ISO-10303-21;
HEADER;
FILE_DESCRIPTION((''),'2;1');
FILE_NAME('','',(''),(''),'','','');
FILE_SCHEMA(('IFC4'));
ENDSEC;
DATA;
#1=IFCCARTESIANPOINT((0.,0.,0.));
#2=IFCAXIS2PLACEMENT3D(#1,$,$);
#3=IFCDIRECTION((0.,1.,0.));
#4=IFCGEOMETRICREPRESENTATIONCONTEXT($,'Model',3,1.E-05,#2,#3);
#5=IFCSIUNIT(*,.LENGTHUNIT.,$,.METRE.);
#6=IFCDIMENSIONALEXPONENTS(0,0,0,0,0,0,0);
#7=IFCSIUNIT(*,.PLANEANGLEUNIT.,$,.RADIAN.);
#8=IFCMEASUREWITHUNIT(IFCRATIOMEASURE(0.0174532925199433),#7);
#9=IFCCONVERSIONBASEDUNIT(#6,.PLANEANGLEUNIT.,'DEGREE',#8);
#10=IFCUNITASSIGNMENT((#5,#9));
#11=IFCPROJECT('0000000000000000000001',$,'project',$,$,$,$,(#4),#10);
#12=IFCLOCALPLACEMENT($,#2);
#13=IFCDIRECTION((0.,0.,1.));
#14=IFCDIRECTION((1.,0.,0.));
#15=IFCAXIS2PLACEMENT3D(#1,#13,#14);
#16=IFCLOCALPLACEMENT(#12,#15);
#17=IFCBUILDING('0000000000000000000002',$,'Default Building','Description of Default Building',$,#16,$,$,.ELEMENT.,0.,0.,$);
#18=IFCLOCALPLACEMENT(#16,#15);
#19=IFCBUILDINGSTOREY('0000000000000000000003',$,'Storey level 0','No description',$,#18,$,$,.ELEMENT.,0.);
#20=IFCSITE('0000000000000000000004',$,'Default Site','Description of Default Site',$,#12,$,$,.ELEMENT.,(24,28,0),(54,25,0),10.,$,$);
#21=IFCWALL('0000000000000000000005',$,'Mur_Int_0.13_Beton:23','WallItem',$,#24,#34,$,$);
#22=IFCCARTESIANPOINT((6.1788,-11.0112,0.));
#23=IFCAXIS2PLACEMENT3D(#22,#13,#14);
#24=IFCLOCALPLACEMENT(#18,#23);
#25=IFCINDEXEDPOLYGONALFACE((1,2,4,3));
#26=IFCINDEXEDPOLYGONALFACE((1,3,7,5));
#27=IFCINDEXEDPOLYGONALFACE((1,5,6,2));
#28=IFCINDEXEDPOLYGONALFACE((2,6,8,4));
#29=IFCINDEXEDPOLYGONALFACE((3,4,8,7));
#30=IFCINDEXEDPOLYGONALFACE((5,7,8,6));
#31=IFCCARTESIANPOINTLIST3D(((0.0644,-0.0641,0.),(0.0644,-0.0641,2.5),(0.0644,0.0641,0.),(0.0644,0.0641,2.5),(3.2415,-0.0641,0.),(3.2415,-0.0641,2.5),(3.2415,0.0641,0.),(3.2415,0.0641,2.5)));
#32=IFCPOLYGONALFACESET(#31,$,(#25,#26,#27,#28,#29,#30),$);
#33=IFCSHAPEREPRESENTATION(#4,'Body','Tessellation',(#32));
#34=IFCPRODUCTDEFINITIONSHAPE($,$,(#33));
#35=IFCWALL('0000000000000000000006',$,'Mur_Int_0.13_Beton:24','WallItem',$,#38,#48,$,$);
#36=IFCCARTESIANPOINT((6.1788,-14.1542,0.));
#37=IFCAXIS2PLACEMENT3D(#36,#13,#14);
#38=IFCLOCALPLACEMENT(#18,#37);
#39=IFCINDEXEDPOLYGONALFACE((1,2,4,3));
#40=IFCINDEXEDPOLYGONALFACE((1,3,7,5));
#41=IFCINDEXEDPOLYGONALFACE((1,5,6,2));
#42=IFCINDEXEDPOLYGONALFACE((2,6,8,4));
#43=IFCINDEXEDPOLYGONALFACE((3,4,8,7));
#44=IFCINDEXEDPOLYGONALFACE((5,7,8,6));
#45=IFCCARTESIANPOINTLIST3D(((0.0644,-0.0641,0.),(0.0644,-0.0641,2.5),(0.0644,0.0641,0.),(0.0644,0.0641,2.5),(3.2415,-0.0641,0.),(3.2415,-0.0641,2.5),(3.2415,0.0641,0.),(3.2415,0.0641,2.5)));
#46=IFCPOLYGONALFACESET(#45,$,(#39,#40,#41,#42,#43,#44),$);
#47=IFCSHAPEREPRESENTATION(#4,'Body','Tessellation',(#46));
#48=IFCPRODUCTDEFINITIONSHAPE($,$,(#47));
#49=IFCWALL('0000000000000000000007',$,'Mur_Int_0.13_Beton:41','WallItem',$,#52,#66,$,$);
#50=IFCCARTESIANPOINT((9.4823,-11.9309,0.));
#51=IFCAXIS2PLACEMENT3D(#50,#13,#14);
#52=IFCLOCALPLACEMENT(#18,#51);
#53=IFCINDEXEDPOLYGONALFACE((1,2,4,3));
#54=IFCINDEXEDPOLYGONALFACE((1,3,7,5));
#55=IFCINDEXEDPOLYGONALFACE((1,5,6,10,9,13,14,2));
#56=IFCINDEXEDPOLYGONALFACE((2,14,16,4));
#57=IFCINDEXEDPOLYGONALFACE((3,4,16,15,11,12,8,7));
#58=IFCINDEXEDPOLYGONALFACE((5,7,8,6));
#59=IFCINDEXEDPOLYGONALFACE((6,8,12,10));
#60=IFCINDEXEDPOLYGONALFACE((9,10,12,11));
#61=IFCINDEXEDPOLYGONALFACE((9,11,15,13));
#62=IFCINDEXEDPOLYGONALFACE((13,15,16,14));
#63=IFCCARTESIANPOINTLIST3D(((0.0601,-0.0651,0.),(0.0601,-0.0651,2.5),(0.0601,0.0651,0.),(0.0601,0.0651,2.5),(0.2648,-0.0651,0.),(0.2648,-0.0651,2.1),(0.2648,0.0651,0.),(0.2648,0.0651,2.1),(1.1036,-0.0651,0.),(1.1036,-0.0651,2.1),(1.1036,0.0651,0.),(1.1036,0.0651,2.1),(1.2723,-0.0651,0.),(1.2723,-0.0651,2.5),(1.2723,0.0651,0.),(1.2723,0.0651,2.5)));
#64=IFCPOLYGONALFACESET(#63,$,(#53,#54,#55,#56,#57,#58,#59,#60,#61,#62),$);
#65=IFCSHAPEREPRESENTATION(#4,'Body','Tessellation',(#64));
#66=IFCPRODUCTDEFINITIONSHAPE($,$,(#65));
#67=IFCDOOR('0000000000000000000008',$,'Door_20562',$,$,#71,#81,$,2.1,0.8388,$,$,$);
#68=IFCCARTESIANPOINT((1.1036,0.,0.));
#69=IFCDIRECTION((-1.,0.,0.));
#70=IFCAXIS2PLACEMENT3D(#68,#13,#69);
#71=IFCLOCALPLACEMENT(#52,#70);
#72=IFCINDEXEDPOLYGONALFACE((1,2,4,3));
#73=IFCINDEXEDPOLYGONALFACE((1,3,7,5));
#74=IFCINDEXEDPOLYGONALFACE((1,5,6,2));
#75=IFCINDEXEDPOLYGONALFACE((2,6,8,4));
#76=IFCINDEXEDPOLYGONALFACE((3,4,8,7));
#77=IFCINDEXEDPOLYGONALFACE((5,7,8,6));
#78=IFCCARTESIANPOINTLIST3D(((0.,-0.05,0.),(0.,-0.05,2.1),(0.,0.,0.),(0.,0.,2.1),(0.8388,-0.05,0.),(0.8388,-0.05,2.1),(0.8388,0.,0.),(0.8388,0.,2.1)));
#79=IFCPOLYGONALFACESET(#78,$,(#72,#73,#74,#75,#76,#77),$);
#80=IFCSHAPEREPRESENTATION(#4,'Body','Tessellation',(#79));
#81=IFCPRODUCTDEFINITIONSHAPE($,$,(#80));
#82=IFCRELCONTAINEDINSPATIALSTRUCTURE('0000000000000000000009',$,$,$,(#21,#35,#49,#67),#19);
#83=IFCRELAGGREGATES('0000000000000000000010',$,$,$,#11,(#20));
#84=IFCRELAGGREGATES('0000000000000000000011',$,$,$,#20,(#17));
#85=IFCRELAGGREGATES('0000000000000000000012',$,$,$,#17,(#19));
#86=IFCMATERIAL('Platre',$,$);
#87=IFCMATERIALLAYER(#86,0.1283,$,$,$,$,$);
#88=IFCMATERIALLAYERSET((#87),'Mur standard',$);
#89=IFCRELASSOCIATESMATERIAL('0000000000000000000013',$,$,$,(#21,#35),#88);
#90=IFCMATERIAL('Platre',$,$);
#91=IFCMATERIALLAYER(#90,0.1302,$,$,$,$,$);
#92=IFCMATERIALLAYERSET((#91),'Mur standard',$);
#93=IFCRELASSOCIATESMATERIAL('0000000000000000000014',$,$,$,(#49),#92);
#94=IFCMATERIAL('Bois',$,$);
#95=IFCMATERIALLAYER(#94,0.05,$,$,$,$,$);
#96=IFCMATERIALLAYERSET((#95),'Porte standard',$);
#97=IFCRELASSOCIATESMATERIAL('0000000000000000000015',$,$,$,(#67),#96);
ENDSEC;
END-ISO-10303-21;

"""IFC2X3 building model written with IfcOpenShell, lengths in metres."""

from ifc_helpers import new_model, entity, si_unit, converted_unit, direction, frame, origin, origin_with_axes, place, context, project, spatial, polyline, outline, extrude, material, layer, layer_set, layer_usage, element, fill, save


model = new_model("IFC2X3")

# Units and contexts
model_context = context("Model", 3, precision=1e-05, world=origin(), true_north=direction((0.0, 1.0, 0.0)))
ifc_project = project(units=[si_unit("LENGTHUNIT", "METRE"), converted_unit("PLANEANGLEUNIT", "DEGREE", entity("IfcRatioMeasure", 0.0174532925199433), si_unit("PLANEANGLEUNIT", "RADIAN"), dimensions=[0, 0, 0, 0, 0, 0, 0])], contexts=[model_context])

# Site, building, storey
site_placement = place(None, origin())
site = spatial("IfcSite", under=ifc_project, at=site_placement, Name="Default Site", Description="Description of Default Site", CompositionType="ELEMENT", RefLatitude=(24, 28, 0), RefLongitude=(54, 25, 0), RefElevation=10.0)
building_placement = place(site_placement, origin_with_axes())
building = spatial("IfcBuilding", under=site, at=building_placement, Name="Default Building", Description="Description of Default Building", CompositionType="ELEMENT", ElevationOfRefHeight=0.0, ElevationOfTerrain=0.0)
storey_placement = place(building_placement, origin_with_axes())
storey = spatial("IfcBuildingStorey", under=building, at=storey_placement, Name="Storey level 0", Description="No description", CompositionType="ELEMENT", Elevation=0.0)

# Shared definitions
ifc_material_1 = material(Name="Platre")
ifc_layer_1 = layer(ifc_material_1, 0.1283)
ifc_layer_set_1 = layer_set([ifc_layer_1], Name="Mur standard")
ifc_layer_usage_1 = layer_usage(ifc_layer_set_1, "AXIS2", "NEGATIVE", 0.1283)
ifc_material_2 = material(Name="Bois")
ifc_layer_2 = layer(ifc_material_2, 0.05)
ifc_layer_set_2 = layer_set([ifc_layer_2], Name="Porte standard")
ifc_layer_usage_2 = layer_usage(ifc_layer_set_2, "AXIS2", "NEGATIVE", 0.05)

# Walls
for number, where, z_axis, x_axis, name in (
    (1, (6.1788, -11.0112, 0.0), (0.0, 0.0, 1.0), (1.0, 0.0, 0.0), "Mur_Int_0.13_Beton:23"),
    (2, (6.1788, -14.1542, 0.0), (0.0, 0.0, 1.0), (1.0, 0.0, 0.0), "Mur_Int_0.13_Beton:24"),
):
    element("IfcWall", number, at=place(storey_placement, frame(where, z_axis=z_axis, x_axis=x_axis)), inside=storey, material=ifc_layer_usage_1, Name=name, Description="WallItem", context=model_context, shape_type="SweptSolid", body=[
        extrude(outline(polyline([(0.0644, 0.0641), (0.0644, -0.0641), (3.2415, -0.0641), (3.2415, 0.0641), (0.0644, 0.0641)])), origin(), (0.0, 0.0, 1.0), 2.5),
    ])

# Wall, opening, door
ifc_material_3 = material(Name="Platre")
ifc_layer_3 = layer(ifc_material_3, 0.1302)
ifc_layer_set_3 = layer_set([ifc_layer_3], Name="Mur standard")
ifc_layer_usage_3 = layer_usage(ifc_layer_set_3, "AXIS2", "NEGATIVE", 0.1302)
wall_1_placement = place(storey_placement, frame((9.4823, -11.9309, 0.0), z_axis=(0.0, 0.0, 1.0), x_axis=(1.0, 0.0, 0.0)))
wall_1 = element("IfcWall", 3, at=wall_1_placement, inside=storey, material=ifc_layer_usage_3, Name="Mur_Int_0.13_Beton:41", Description="WallItem", context=model_context, shape_type="SweptSolid", body=[
    extrude(outline(polyline([(0.0601, 0.0651), (0.0601, -0.0651), (1.2723, -0.0651), (1.2723, 0.0651), (0.0601, 0.0651)])), origin(), (0.0, 0.0, 1.0), 2.5),
])
opening_1_placement = place(storey_placement, frame((10.5859, -11.8658, 0.0), z_axis=(0.0, 0.0, 1.0), x_axis=(-1.0, 0.0, 0.0)))
opening_1 = element("IfcOpeningElement", 4, at=opening_1_placement, cuts=wall_1, context=model_context, shape_type="SweptSolid", body=[
    extrude(outline(polyline([(0.8388, 0.1802), (0.0, 0.1802), (0.0, -0.05), (0.8388, -0.05), (0.8388, 0.1802)])), origin(), (0.0, 0.0, 1.0), 2.1),
])
door_1_placement = place(wall_1_placement, frame((1.1036, 0.0, 0.0), z_axis=(0.0, 0.0, 1.0), x_axis=(-1.0, 0.0, 0.0)))
door_1 = element("IfcDoor", 5, at=door_1_placement, inside=storey, material=ifc_layer_usage_2, Name="Door_20562", OverallHeight=2.1, OverallWidth=0.8388, context=model_context, shape_type="SweptSolid", body=[
    extrude(outline(polyline([(0.0, 0.0), (0.8388, 0.0), (0.8388, -0.05), (0.0, -0.05), (0.0, 0.0)])), origin(), (0.0, 0.0, 1.0), 2.1),
])
fill(opening_1, door_1)

save(model, "model.ifc")
